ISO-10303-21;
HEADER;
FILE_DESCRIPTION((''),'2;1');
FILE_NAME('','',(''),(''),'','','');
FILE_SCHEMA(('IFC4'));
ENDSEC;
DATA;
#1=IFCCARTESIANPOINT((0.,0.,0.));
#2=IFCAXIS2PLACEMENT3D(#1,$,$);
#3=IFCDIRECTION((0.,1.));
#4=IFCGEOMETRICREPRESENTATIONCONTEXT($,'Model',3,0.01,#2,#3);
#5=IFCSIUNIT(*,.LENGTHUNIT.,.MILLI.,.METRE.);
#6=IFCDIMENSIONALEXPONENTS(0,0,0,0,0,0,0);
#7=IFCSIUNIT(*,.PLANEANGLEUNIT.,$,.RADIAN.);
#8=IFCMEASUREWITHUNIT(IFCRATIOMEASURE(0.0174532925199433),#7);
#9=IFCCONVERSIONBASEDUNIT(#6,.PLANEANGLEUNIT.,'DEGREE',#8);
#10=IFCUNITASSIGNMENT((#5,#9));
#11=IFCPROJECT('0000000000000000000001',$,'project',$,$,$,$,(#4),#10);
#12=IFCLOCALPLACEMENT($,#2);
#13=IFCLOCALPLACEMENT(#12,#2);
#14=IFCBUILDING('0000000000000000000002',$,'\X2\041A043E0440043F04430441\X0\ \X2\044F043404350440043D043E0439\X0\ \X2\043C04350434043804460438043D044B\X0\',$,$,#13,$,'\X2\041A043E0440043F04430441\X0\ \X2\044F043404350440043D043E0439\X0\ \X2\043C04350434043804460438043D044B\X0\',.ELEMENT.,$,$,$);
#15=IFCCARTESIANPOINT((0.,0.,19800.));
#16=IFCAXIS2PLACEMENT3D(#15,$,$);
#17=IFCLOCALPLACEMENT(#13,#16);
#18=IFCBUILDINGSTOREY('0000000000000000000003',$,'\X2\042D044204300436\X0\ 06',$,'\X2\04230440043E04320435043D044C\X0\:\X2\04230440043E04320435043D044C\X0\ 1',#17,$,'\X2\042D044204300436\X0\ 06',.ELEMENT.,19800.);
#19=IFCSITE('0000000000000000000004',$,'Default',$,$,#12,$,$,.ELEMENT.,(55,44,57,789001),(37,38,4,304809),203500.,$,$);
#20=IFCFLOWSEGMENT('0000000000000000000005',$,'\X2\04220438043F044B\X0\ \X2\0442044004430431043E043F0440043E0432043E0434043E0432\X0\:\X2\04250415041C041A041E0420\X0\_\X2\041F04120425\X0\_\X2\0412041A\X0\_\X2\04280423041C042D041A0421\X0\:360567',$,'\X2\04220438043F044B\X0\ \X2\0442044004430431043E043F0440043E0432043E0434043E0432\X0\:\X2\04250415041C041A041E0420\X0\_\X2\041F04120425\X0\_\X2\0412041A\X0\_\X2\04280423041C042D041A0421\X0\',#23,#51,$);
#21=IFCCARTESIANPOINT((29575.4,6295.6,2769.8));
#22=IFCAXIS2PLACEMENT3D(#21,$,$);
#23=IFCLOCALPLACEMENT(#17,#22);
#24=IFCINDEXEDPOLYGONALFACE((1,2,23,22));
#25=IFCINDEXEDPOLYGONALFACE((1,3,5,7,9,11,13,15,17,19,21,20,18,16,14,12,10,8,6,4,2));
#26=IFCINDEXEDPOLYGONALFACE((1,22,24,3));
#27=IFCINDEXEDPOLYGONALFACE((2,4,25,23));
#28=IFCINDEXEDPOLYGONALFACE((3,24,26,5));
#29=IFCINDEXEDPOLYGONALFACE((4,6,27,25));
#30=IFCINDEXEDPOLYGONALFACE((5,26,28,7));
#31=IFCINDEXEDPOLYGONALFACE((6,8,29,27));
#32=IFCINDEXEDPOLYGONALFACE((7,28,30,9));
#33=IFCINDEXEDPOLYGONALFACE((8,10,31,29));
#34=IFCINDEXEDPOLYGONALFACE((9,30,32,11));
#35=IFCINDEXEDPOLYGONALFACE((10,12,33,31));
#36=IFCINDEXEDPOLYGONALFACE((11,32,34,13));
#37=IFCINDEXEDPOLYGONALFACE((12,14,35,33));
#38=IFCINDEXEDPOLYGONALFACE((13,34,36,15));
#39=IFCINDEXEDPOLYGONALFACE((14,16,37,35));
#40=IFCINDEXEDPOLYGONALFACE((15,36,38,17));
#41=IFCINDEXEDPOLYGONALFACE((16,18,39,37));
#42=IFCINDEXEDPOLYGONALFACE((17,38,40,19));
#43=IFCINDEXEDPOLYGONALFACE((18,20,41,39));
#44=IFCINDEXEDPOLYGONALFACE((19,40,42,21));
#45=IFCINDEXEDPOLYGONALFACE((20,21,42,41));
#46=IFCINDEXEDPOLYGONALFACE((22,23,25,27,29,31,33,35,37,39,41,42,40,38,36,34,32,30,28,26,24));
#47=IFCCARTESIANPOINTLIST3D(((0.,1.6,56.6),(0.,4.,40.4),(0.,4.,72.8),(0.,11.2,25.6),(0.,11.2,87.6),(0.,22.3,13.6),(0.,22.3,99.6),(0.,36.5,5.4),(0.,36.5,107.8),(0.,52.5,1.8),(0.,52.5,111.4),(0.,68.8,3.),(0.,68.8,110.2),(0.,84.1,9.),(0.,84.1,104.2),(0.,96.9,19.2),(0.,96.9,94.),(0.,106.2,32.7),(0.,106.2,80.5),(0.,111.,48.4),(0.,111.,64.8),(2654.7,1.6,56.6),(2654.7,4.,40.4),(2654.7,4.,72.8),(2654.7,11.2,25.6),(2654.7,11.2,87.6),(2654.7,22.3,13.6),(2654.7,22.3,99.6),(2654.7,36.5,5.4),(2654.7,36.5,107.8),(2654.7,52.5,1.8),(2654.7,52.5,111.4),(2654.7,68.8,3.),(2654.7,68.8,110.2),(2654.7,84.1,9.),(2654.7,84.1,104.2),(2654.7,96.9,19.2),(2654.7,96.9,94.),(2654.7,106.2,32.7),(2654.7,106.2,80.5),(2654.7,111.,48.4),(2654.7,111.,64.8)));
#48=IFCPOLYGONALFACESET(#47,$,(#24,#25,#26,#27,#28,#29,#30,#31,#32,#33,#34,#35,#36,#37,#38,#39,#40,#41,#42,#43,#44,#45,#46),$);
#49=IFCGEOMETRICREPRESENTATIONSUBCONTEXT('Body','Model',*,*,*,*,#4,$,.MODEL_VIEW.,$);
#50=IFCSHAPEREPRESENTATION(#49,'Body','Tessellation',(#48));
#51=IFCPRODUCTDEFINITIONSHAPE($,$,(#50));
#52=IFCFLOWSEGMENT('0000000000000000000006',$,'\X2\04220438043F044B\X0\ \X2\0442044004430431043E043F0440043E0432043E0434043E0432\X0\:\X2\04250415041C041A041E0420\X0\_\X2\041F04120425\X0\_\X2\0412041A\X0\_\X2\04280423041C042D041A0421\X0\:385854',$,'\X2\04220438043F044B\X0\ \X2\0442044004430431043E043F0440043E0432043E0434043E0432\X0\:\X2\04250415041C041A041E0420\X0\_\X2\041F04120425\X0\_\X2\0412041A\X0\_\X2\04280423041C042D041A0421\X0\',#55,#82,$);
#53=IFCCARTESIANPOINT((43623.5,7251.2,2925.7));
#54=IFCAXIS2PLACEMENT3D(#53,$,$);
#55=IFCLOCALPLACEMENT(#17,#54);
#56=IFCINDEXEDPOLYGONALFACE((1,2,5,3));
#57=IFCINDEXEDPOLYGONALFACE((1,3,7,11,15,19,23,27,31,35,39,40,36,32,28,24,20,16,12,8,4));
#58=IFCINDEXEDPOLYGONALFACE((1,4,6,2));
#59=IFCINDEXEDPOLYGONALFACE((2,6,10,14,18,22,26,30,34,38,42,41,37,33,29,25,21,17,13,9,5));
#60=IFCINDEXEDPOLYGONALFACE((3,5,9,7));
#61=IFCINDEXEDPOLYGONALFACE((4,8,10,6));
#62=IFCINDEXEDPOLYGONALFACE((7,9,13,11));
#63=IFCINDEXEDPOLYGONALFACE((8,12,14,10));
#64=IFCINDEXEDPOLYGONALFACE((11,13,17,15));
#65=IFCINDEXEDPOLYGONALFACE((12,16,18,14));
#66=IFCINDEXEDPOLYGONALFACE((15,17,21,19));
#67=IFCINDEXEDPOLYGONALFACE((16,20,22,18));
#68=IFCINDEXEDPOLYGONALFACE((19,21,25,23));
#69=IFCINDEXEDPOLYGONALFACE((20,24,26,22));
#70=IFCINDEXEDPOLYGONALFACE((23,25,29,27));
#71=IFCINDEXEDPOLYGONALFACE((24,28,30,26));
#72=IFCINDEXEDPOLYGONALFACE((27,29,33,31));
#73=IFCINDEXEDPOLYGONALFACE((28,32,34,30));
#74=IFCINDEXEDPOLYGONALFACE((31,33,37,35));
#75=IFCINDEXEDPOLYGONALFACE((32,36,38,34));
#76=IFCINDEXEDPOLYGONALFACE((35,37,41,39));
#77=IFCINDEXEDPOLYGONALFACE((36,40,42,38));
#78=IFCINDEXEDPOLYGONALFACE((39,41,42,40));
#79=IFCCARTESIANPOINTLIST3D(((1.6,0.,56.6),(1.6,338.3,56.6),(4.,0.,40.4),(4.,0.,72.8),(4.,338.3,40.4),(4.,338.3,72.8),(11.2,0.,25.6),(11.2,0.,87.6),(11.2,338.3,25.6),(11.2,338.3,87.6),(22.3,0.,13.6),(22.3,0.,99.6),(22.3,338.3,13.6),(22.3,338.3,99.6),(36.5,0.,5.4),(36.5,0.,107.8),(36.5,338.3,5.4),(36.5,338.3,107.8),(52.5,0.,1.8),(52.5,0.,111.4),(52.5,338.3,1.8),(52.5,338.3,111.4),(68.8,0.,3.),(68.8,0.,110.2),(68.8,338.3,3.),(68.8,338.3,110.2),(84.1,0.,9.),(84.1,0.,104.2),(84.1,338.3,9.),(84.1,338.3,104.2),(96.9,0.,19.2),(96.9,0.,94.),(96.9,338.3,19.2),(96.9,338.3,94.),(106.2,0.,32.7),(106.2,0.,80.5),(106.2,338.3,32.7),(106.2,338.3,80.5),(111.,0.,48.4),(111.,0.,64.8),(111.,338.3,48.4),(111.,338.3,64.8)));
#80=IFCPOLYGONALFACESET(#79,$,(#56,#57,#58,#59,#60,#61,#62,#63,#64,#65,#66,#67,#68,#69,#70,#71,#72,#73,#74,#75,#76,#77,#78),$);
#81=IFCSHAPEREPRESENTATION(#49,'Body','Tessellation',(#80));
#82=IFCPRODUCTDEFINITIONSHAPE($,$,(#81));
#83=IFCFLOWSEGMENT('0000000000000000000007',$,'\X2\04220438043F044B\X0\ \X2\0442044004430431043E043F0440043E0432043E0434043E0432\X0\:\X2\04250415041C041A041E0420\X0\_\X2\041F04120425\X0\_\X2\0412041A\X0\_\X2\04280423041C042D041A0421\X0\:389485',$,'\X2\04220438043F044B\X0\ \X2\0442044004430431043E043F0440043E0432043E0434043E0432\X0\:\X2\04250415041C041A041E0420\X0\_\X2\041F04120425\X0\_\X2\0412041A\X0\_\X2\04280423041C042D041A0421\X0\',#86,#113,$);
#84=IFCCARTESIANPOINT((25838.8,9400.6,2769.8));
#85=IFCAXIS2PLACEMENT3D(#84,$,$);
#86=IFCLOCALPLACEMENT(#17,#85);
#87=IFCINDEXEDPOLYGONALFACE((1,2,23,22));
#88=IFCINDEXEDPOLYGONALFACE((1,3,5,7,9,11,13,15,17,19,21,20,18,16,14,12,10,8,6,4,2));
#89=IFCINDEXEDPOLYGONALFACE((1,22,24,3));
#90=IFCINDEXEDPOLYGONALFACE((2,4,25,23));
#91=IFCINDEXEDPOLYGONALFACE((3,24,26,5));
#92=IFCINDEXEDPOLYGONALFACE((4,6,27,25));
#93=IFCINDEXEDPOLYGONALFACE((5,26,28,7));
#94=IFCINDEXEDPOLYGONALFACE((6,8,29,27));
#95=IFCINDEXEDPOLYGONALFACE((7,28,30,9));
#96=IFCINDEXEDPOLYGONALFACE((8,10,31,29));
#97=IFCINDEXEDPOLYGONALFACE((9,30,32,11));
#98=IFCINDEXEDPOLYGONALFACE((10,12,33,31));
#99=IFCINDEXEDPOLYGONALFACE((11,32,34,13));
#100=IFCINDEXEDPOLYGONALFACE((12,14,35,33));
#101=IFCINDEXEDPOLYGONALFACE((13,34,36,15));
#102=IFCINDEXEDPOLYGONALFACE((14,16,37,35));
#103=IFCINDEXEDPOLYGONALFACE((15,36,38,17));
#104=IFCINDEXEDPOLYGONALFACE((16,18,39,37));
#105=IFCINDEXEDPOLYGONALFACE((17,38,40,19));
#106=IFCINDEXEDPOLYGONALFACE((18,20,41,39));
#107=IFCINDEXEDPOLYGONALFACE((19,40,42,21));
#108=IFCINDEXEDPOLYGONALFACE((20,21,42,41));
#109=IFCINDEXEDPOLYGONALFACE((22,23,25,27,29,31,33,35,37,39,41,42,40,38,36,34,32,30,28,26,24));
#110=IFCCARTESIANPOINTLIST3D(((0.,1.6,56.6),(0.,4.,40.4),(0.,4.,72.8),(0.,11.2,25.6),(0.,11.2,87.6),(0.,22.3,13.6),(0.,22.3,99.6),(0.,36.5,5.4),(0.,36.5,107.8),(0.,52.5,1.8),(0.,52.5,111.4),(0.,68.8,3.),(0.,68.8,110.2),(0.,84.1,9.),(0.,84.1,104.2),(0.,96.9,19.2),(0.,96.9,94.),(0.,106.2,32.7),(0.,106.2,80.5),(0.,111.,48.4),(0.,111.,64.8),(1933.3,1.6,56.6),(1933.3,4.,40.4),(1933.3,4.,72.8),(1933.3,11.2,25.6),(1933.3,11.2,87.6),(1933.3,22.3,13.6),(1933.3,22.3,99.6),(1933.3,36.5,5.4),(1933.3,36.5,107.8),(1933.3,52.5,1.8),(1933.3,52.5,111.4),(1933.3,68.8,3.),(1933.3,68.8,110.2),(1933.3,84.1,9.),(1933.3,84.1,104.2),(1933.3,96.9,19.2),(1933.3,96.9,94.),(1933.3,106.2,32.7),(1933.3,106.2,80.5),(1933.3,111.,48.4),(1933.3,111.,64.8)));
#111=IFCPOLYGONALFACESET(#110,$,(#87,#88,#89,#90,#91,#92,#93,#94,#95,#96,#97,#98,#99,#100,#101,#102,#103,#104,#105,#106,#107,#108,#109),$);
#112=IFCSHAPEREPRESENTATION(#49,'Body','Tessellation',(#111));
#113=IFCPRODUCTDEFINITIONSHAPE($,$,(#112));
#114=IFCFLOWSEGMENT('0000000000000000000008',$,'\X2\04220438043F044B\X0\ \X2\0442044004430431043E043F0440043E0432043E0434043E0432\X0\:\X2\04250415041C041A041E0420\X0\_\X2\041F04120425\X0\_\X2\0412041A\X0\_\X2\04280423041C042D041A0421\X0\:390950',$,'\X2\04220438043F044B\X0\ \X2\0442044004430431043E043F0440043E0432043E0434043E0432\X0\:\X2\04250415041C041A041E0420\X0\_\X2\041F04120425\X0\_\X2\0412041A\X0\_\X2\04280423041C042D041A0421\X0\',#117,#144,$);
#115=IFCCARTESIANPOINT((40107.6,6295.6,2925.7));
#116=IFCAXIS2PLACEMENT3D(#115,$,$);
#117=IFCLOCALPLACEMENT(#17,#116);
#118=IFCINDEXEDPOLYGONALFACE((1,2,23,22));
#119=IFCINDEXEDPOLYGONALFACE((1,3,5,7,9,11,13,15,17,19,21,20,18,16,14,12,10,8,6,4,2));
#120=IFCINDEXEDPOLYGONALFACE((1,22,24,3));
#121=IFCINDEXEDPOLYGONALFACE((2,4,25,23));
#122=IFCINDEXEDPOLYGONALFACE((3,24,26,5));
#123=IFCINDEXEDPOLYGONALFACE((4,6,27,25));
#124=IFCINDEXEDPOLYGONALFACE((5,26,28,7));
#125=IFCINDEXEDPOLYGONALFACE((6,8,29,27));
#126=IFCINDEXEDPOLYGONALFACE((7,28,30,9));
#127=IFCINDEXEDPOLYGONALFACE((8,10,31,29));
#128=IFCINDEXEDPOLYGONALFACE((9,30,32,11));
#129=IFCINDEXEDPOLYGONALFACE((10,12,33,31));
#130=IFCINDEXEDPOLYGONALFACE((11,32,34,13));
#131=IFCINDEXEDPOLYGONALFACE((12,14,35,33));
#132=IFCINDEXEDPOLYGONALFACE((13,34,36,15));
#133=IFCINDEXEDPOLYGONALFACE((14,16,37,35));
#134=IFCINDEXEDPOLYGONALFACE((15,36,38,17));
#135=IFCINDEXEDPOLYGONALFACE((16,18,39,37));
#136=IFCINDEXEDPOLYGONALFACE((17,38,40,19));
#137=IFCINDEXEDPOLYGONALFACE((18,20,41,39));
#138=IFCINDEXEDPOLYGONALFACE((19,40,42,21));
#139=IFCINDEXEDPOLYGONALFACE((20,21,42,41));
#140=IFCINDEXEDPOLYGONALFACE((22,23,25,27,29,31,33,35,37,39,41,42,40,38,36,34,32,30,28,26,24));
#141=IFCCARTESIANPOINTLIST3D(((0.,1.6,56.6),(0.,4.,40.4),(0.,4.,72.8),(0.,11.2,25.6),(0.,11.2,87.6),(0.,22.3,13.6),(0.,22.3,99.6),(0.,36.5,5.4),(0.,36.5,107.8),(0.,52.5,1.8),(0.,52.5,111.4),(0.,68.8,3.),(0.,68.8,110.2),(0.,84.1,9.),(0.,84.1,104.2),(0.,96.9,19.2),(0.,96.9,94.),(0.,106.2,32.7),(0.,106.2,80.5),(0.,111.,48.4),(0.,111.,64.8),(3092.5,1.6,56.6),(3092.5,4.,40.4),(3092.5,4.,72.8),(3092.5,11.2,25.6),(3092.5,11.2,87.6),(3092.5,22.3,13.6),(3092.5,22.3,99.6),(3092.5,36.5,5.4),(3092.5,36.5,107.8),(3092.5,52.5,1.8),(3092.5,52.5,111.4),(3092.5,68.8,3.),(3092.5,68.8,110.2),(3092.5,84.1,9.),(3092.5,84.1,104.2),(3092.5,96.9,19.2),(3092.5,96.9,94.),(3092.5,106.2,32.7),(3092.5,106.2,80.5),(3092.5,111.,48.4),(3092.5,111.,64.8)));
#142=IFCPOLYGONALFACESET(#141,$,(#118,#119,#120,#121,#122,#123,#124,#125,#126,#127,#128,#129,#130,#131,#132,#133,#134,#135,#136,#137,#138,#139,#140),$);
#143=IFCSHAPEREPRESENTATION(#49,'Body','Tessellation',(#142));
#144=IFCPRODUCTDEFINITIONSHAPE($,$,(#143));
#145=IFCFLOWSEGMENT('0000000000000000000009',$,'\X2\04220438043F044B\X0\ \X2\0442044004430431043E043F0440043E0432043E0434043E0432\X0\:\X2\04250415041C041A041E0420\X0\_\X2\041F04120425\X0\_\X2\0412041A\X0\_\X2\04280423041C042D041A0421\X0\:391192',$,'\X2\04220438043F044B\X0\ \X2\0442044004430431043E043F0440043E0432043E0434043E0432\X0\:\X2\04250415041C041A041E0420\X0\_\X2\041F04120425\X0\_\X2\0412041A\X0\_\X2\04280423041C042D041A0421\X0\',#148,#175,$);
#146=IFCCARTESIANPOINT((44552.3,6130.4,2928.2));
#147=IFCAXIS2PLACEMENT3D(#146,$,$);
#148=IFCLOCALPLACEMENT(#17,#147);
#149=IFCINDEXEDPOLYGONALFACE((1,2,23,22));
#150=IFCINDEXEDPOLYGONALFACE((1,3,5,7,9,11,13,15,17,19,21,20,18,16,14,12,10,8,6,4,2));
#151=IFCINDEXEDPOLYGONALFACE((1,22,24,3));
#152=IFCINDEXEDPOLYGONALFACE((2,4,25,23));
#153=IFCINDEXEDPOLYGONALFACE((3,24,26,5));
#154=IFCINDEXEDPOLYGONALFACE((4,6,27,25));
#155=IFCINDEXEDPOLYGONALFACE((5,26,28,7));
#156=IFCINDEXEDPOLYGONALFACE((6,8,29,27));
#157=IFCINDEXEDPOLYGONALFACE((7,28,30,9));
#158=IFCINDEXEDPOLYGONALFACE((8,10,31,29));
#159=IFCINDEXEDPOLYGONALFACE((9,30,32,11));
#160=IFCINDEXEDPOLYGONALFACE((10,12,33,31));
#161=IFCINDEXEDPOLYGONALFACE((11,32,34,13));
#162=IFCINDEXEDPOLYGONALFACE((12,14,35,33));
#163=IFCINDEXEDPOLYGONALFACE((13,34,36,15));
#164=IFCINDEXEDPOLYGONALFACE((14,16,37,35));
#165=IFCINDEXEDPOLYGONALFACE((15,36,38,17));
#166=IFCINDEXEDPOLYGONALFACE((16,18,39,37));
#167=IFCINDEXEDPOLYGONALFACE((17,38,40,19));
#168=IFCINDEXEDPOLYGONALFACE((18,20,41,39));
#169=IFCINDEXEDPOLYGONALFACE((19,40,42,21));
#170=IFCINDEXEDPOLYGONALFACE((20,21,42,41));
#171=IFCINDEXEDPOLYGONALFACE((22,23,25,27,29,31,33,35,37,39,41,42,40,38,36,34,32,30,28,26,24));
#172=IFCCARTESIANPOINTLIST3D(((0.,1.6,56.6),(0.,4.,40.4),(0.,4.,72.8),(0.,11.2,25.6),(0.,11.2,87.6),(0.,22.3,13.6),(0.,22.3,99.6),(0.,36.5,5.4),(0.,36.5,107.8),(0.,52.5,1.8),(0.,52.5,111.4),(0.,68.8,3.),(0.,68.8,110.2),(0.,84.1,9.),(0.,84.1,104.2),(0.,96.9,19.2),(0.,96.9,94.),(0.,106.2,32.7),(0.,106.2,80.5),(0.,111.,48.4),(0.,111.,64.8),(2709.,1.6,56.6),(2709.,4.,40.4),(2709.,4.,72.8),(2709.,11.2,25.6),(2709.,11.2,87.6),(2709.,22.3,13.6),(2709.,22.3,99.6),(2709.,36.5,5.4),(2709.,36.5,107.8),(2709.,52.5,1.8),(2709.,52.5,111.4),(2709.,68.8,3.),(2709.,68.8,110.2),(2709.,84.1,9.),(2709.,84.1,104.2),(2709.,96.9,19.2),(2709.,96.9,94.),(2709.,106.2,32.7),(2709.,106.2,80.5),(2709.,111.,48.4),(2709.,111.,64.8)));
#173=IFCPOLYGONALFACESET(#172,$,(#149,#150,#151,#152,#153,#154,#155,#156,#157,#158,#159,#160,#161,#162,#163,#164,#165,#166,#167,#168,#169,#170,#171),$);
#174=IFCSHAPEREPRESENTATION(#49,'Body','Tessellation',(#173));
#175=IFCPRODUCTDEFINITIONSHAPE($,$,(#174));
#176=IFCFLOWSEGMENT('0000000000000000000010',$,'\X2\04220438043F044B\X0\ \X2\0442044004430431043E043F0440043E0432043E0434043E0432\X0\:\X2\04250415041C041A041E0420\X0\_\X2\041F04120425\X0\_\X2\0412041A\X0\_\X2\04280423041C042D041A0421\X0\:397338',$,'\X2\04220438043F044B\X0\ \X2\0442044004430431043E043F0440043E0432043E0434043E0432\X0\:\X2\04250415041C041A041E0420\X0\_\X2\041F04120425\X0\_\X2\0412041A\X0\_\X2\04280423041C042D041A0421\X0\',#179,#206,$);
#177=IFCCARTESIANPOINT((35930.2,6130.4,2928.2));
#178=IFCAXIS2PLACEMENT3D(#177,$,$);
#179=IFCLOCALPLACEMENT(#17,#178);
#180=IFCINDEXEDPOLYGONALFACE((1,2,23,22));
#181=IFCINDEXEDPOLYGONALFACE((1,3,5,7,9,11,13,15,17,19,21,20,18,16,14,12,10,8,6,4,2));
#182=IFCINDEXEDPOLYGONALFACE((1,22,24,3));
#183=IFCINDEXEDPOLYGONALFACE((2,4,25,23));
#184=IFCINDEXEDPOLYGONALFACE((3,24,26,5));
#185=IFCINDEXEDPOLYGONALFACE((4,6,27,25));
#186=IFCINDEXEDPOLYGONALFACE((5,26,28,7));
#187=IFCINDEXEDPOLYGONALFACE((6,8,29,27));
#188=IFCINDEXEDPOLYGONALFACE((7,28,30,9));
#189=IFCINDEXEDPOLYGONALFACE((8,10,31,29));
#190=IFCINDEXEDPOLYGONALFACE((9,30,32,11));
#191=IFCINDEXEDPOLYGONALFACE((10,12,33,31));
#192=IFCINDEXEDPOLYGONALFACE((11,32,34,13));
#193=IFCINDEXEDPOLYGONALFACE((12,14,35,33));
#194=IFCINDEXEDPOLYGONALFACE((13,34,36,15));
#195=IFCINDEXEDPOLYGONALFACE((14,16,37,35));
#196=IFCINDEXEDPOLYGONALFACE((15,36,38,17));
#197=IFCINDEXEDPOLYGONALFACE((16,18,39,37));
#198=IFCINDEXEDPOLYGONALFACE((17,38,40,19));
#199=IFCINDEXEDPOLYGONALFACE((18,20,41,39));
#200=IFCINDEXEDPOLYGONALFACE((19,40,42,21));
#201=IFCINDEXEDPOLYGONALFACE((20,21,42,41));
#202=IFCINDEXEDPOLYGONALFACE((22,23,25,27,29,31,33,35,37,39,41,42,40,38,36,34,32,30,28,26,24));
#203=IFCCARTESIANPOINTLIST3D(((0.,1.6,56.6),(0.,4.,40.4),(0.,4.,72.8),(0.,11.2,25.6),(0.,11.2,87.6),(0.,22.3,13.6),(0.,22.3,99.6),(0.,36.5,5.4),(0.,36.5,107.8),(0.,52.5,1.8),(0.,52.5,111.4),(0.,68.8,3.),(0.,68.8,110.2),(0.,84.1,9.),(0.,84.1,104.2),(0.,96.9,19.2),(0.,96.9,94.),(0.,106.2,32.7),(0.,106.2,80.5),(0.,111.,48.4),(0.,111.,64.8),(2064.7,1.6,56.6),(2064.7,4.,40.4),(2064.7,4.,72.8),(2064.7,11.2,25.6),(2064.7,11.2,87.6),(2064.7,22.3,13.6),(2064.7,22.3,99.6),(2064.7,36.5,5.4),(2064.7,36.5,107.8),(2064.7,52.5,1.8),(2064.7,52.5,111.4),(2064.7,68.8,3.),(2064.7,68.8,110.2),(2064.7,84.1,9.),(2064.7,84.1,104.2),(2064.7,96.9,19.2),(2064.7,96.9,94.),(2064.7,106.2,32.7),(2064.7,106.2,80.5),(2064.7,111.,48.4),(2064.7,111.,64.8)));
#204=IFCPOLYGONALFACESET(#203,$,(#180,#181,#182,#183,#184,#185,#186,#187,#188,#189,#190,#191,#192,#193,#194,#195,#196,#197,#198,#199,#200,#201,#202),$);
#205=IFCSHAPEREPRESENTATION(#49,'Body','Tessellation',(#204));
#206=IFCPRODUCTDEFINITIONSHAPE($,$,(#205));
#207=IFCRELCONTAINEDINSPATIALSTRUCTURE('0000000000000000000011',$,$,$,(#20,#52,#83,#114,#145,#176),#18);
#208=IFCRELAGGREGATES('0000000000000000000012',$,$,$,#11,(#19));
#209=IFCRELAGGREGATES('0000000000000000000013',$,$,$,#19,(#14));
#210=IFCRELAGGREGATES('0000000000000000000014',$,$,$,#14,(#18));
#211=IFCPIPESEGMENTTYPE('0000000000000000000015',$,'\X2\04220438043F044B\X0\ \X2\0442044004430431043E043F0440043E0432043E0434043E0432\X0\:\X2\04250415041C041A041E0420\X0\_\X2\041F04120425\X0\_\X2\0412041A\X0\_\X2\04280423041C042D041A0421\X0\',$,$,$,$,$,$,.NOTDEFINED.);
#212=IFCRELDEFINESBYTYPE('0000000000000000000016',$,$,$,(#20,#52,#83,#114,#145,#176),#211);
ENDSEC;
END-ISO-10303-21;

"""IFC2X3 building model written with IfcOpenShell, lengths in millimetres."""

from ifc_helpers import new_model, entity, si_unit, converted_unit, direction, frame, origin, origin_2d_with_axis, place, context, subcontext, project, spatial, circle, extrude, type_object, element, save


model = new_model("IFC2X3")

# Units and contexts
model_context = context("Model", 3, precision=0.01, world=origin(), true_north=direction((0.0, 1.0)))
body_context = subcontext(model_context, "Body", "Model", "MODEL_VIEW")
ifc_project = project(units=[si_unit("LENGTHUNIT", "METRE", prefix="MILLI"), converted_unit("PLANEANGLEUNIT", "DEGREE", entity("IfcRatioMeasure", 0.0174532925199433), si_unit("PLANEANGLEUNIT", "RADIAN"), dimensions=[0, 0, 0, 0, 0, 0, 0])], contexts=[model_context])

# Site, building, storey
site_placement = place(None, origin())
site = spatial("IfcSite", under=ifc_project, at=site_placement, Name="Default", CompositionType="ELEMENT", RefLatitude=(55, 44, 57, 789001), RefLongitude=(37, 38, 4, 304809), RefElevation=203500.0)
building_placement = place(site_placement, origin())
building = spatial("IfcBuilding", under=site, at=building_placement, Name="Корпус ядерной медицины", LongName="Корпус ядерной медицины", CompositionType="ELEMENT")
storey_placement = place(building_placement, frame((0.0, 0.0, 19800.0)))
storey = spatial("IfcBuildingStorey", under=building, at=storey_placement, Name="Этаж 06", ObjectType="Уровень:Уровень 1", LongName="Этаж 06", CompositionType="ELEMENT", Elevation=19800.0)

# Flow segments
pipe_segment_type = type_object("IfcPipeSegmentType", Name="Типы трубопроводов:ХЕМКОР_ПВХ_ВК_ШУМЭКС", PredefinedType="NOTDEFINED")
flow_segment_1_placement = place(storey_placement, frame((29575.4, 6295.6, 2769.8)))
element("IfcFlowSegment", 1, at=flow_segment_1_placement, inside=storey, type_object=pipe_segment_type, Name="Типы трубопроводов:ХЕМКОР_ПВХ_ВК_ШУМЭКС:360567", ObjectType="Типы трубопроводов:ХЕМКОР_ПВХ_ВК_ШУМЭКС", context=body_context, shape_type="SweptSolid", body=[
    extrude(circle(Radius=55.0, at=origin_2d_with_axis()), frame((0.0, 56.6, 56.6), z_axis=(1.0, 0.0, 0.0), x_axis=(0.0, -1.0, 0.0)), (0.0, 0.0, 1.0), 2654.7),
])
flow_segment_2_placement = place(storey_placement, frame((43623.5, 7251.2, 2925.7)))
element("IfcFlowSegment", 2, at=flow_segment_2_placement, inside=storey, type_object=pipe_segment_type, Name="Типы трубопроводов:ХЕМКОР_ПВХ_ВК_ШУМЭКС:385854", ObjectType="Типы трубопроводов:ХЕМКОР_ПВХ_ВК_ШУМЭКС", context=body_context, shape_type="SweptSolid", body=[
    extrude(circle(Radius=55.0, at=origin_2d_with_axis()), frame((56.6, 0.0, 56.6), z_axis=(0.0, 1.0, 0.0), x_axis=(-1.0, 0.0, 0.0)), (0.0, 0.0, 1.0), 338.3),
])
flow_segment_3_placement = place(storey_placement, frame((25838.8, 9400.6, 2769.8)))
element("IfcFlowSegment", 3, at=flow_segment_3_placement, inside=storey, type_object=pipe_segment_type, Name="Типы трубопроводов:ХЕМКОР_ПВХ_ВК_ШУМЭКС:389485", ObjectType="Типы трубопроводов:ХЕМКОР_ПВХ_ВК_ШУМЭКС", context=body_context, shape_type="SweptSolid", body=[
    extrude(circle(Radius=55.0, at=origin_2d_with_axis()), frame((0.0, 56.6, 56.6), z_axis=(1.0, 0.0, 0.0), x_axis=(0.0, -1.0, 0.0)), (0.0, 0.0, 1.0), 1933.3),
])
flow_segment_4_placement = place(storey_placement, frame((40107.6, 6295.6, 2925.7)))
element("IfcFlowSegment", 4, at=flow_segment_4_placement, inside=storey, type_object=pipe_segment_type, Name="Типы трубопроводов:ХЕМКОР_ПВХ_ВК_ШУМЭКС:390950", ObjectType="Типы трубопроводов:ХЕМКОР_ПВХ_ВК_ШУМЭКС", context=body_context, shape_type="SweptSolid", body=[
    extrude(circle(Radius=55.0, at=origin_2d_with_axis()), frame((0.0, 56.6, 56.6), z_axis=(1.0, 0.0, 0.0), x_axis=(0.0, -1.0, 0.0)), (0.0, 0.0, 1.0), 3092.5),
])
flow_segment_5_placement = place(storey_placement, frame((44552.3, 6130.4, 2928.2)))
element("IfcFlowSegment", 5, at=flow_segment_5_placement, inside=storey, type_object=pipe_segment_type, Name="Типы трубопроводов:ХЕМКОР_ПВХ_ВК_ШУМЭКС:391192", ObjectType="Типы трубопроводов:ХЕМКОР_ПВХ_ВК_ШУМЭКС", context=body_context, shape_type="SweptSolid", body=[
    extrude(circle(Radius=55.0, at=origin_2d_with_axis()), frame((0.0, 56.6, 56.6), z_axis=(1.0, 0.0, 0.0), x_axis=(0.0, -1.0, 0.0)), (0.0, 0.0, 1.0), 2709.0),
])
flow_segment_6_placement = place(storey_placement, frame((35930.2, 6130.4, 2928.2)))
element("IfcFlowSegment", 6, at=flow_segment_6_placement, inside=storey, type_object=pipe_segment_type, Name="Типы трубопроводов:ХЕМКОР_ПВХ_ВК_ШУМЭКС:397338", ObjectType="Типы трубопроводов:ХЕМКОР_ПВХ_ВК_ШУМЭКС", context=body_context, shape_type="SweptSolid", body=[
    extrude(circle(Radius=55.0, at=origin_2d_with_axis()), frame((0.0, 56.6, 56.6), z_axis=(1.0, 0.0, 0.0), x_axis=(0.0, -1.0, 0.0)), (0.0, 0.0, 1.0), 2064.7),
])

save(model, "model.ifc")
